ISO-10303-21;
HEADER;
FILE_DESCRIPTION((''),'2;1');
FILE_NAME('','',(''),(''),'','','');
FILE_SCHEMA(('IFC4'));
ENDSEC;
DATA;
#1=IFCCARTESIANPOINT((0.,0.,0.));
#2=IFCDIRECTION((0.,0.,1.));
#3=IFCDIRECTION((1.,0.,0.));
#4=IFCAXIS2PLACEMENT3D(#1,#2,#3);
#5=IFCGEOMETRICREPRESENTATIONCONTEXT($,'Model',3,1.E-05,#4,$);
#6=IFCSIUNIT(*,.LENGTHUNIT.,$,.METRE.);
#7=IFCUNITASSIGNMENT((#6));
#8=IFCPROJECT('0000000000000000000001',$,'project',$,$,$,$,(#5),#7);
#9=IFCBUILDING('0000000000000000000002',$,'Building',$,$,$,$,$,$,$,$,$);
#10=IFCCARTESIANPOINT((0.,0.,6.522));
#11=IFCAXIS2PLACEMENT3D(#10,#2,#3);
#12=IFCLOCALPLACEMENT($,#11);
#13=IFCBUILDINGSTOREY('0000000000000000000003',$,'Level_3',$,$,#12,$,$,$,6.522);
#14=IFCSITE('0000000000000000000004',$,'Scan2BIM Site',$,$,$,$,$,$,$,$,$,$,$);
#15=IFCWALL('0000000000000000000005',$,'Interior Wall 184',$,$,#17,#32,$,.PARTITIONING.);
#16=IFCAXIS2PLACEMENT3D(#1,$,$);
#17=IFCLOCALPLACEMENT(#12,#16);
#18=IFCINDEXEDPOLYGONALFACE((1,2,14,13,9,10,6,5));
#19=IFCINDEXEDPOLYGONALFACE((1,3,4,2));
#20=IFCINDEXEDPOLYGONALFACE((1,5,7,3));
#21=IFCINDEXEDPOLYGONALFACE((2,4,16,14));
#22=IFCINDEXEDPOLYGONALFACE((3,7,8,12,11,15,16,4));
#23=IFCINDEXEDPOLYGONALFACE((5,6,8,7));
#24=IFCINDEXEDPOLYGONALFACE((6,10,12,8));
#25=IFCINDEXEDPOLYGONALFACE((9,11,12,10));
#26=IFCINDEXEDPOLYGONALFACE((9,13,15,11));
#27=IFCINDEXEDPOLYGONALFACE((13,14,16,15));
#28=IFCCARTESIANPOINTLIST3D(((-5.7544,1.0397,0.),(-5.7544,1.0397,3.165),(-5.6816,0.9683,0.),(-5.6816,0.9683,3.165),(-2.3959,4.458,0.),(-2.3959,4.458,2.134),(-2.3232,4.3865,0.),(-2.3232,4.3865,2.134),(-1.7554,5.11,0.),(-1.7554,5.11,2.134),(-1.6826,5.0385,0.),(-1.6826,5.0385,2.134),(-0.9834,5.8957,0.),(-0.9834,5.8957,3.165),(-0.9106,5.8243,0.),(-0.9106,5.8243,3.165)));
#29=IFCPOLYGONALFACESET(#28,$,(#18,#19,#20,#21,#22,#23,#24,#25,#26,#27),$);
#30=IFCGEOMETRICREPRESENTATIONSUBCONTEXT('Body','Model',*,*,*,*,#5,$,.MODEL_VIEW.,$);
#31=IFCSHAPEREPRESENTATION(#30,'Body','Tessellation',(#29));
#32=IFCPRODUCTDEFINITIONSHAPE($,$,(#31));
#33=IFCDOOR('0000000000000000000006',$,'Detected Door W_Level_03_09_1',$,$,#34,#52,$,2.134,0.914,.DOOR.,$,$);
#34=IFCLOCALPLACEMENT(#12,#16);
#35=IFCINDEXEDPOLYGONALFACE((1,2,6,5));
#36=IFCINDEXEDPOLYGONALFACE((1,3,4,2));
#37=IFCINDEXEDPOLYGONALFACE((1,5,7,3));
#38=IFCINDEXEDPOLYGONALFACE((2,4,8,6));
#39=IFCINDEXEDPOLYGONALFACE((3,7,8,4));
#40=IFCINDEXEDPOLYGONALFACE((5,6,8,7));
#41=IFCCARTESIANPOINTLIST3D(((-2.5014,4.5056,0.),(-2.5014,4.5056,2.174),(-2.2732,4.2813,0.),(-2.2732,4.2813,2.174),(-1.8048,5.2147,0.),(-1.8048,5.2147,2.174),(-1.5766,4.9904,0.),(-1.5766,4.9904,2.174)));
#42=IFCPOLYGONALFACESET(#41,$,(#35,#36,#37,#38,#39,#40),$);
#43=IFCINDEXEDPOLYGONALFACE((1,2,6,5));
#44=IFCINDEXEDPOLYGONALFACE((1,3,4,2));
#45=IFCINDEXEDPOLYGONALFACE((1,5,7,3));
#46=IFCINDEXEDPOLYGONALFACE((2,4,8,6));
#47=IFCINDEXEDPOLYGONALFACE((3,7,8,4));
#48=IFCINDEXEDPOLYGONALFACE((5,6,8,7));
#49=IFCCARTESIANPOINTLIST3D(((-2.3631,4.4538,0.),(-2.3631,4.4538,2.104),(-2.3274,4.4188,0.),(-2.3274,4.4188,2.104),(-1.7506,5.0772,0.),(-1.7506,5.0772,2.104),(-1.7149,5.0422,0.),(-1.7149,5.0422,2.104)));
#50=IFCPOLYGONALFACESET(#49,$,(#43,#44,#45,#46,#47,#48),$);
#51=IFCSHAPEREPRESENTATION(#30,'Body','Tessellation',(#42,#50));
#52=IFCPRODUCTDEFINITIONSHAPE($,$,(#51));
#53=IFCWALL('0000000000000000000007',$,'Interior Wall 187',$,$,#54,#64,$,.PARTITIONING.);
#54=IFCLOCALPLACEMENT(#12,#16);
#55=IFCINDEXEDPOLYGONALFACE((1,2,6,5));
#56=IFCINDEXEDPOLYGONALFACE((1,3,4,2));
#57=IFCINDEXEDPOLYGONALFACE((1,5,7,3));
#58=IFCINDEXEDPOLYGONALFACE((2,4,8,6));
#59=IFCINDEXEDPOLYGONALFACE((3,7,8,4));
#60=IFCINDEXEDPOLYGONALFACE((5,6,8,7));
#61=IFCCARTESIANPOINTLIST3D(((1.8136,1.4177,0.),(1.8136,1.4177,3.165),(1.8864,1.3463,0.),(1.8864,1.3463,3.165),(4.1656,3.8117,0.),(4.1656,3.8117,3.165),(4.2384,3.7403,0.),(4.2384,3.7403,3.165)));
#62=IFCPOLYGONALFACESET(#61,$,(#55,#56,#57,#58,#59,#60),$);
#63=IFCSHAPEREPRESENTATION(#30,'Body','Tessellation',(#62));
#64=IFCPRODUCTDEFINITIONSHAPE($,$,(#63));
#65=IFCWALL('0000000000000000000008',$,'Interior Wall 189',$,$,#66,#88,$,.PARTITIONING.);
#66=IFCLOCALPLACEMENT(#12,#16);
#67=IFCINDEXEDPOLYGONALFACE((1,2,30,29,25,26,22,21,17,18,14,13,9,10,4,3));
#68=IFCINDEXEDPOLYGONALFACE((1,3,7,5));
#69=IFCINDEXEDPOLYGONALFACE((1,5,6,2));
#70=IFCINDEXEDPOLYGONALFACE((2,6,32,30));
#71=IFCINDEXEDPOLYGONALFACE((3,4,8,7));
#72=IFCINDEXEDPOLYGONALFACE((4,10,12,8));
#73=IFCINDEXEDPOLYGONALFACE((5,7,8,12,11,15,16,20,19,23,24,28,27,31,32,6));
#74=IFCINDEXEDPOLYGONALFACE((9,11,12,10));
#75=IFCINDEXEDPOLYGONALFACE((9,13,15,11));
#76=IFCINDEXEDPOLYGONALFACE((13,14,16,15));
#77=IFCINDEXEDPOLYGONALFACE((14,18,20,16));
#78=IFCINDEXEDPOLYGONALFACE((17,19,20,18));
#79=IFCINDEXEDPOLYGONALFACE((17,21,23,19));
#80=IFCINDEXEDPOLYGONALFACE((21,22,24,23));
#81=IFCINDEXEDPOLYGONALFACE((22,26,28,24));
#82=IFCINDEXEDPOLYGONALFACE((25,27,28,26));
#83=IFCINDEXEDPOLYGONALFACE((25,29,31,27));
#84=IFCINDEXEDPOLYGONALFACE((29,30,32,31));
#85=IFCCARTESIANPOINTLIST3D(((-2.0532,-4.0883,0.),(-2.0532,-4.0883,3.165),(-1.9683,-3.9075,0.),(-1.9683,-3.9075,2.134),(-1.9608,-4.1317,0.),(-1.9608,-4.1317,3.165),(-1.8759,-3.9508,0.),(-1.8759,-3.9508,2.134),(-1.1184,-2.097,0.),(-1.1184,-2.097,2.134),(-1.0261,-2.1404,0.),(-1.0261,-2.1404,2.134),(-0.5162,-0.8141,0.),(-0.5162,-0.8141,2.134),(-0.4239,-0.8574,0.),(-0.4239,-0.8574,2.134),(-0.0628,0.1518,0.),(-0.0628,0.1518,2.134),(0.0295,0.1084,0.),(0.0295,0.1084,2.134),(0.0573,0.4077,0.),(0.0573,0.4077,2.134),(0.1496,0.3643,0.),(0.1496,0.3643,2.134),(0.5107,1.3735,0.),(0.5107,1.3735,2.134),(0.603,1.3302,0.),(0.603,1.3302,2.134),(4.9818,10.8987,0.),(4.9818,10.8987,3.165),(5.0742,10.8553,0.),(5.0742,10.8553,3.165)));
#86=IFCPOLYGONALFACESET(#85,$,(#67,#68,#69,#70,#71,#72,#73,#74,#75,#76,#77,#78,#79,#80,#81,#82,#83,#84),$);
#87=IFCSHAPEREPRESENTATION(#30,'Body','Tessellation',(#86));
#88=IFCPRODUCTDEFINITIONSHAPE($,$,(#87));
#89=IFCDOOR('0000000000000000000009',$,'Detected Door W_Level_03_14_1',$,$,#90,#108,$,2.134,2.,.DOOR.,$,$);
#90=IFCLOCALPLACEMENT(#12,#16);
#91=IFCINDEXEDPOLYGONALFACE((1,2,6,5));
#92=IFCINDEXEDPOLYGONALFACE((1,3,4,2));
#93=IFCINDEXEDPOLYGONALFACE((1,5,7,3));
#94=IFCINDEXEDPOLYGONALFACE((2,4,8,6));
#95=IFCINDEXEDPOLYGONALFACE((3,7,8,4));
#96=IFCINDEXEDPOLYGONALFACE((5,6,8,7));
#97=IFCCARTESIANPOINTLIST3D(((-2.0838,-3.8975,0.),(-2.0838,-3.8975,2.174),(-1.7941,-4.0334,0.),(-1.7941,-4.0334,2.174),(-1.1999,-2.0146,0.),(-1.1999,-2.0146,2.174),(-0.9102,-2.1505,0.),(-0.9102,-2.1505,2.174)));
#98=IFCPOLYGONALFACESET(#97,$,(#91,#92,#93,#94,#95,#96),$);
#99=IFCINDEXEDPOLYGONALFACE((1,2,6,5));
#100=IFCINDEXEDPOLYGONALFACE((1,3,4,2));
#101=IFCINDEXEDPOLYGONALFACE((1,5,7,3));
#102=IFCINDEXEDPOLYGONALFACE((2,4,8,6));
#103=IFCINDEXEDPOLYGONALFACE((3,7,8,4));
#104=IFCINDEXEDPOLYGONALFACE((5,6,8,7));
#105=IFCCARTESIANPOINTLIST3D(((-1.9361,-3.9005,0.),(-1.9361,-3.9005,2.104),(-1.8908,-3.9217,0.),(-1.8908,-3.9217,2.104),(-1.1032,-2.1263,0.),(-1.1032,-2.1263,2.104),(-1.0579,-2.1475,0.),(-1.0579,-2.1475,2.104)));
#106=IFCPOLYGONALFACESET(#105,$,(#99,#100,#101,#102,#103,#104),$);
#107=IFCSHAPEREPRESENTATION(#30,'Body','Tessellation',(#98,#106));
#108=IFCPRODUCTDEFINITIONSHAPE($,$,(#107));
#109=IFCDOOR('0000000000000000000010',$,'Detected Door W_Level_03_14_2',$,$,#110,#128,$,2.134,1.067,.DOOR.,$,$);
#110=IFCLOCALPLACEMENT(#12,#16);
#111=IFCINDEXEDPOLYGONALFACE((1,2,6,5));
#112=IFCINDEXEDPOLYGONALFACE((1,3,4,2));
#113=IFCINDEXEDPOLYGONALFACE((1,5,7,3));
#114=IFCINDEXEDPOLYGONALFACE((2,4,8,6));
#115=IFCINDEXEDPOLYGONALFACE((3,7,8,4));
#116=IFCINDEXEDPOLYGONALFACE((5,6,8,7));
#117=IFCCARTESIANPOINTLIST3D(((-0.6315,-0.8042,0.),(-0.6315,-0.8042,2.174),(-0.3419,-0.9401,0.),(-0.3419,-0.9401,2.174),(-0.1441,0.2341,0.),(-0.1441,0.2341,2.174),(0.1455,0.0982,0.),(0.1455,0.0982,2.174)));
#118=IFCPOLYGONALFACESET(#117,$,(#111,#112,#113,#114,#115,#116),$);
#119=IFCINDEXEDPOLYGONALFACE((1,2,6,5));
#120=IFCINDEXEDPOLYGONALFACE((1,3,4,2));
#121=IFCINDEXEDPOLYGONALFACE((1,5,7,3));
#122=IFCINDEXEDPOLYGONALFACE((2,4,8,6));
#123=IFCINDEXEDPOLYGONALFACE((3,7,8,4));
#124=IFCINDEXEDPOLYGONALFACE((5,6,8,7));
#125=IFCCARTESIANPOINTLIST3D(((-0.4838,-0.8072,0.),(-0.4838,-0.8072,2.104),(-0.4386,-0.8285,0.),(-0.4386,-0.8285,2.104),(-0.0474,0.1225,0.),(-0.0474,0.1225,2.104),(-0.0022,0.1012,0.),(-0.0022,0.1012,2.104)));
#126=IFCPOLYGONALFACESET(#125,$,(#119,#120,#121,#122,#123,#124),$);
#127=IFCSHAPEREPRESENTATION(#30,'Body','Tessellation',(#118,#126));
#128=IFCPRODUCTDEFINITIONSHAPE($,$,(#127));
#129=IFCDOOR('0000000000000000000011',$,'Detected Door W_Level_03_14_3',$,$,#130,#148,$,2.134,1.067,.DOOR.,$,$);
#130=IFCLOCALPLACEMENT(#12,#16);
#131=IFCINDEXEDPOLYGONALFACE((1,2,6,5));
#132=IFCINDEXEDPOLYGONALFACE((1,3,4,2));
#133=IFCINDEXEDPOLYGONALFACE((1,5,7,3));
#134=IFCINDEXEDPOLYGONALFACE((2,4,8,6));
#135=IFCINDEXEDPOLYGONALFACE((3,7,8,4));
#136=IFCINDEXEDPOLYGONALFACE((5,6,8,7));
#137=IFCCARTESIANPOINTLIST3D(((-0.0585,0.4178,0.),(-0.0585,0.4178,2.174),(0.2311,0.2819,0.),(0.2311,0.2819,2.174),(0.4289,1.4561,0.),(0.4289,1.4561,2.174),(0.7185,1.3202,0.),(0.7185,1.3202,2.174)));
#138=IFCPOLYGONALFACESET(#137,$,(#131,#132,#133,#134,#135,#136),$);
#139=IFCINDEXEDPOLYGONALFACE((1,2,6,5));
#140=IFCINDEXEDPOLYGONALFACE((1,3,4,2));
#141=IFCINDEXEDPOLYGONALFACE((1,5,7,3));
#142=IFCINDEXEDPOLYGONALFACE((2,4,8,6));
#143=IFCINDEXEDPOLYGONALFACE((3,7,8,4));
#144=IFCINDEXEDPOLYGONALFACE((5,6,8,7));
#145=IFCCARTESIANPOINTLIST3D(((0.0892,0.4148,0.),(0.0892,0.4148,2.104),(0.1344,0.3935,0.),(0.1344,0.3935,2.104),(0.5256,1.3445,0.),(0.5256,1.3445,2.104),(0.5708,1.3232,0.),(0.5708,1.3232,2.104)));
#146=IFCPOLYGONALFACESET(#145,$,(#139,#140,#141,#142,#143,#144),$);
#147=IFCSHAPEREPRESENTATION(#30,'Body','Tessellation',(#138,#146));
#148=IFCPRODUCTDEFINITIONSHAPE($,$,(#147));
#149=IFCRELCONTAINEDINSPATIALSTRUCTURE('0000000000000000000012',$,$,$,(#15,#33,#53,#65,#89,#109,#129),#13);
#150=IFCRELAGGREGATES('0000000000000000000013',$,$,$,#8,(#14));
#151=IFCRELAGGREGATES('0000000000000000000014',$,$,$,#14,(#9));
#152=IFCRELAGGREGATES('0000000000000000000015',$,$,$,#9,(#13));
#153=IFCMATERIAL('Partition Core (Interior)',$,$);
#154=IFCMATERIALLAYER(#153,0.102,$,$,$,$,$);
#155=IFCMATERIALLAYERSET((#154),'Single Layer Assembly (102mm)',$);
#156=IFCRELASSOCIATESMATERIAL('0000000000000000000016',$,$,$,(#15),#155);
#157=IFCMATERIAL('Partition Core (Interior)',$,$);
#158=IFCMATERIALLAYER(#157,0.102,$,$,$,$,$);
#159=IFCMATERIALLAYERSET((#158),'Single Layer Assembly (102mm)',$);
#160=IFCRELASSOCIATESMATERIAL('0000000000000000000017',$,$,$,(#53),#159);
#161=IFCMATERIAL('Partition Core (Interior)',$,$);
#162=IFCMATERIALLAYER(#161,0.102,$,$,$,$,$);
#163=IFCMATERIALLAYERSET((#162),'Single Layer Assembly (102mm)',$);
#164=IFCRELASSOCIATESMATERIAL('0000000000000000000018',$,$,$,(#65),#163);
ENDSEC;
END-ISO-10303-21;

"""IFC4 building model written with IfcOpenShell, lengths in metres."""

from ifc_helpers import new_model, si_unit, frame, origin, origin_with_axes, place, context, subcontext, project, spatial, rectangle, extrude, material, layer, layer_set, element, fill, save


model = new_model("IFC4")

# Units and contexts
model_context = context("Model", 3, precision=1e-05, world=origin_with_axes())
body_context = subcontext(model_context, "Body", "Model", "MODEL_VIEW")
ifc_project = project(units=[si_unit("LENGTHUNIT", "METRE")], contexts=[model_context])

# Site, building, storey
site = spatial("IfcSite", under=ifc_project, Name="Scan2BIM Site")
building = spatial("IfcBuilding", under=site, Name="Building")
storey_placement = place(None, frame((0.0, 0.0, 6.522), z_axis=(0.0, 0.0, 1.0), x_axis=(1.0, 0.0, 0.0)))
storey = spatial("IfcBuildingStorey", under=building, at=storey_placement, Name="Level_3", Elevation=6.522)

# Wall, opening, door
ifc_material_1 = material(Name="Partition Core (Interior)")
ifc_layer_1 = layer(ifc_material_1, 0.102)
ifc_layer_set_1 = layer_set([ifc_layer_1], Name="Single Layer Assembly (102mm)")
wall_1_placement = place(storey_placement, frame((-3.3325, 3.432, 0.0), z_axis=(0.0, 0.0, 1.0), x_axis=(0.700836, 0.713322, 0.0)))
wall_1 = element("IfcWall", 1, at=wall_1_placement, inside=storey, material=ifc_layer_set_1, Name="Interior Wall 184", PredefinedType="PARTITIONING", context=body_context, shape_type="SweptSolid", body=[
    extrude(rectangle(XDim=6.8076, YDim=0.102), origin(), (0.0, 0.0, 1.0), 3.165),
])
opening_1_placement = place(None, frame((-2.039, 4.748, 6.522), z_axis=(0.0, 0.0, 1.0), x_axis=(0.700836, 0.713322, 0.0)))
opening_1 = element("IfcOpeningElement", 2, at=opening_1_placement, cuts=wall_1, PredefinedType="OPENING", context=body_context, shape_type="SweptSolid", body=[
    extrude(rectangle(XDim=0.914, YDim=0.202), origin(), (0.0, 0.0, 1.0), 2.134),
])
door_1_placement = place(opening_1_placement, frame((0.0, 0.0, 0.0), z_axis=(0.0, 0.0, 1.0), x_axis=(1.0, 0.0, 0.0)))
door_1 = element("IfcDoor", 3, at=door_1_placement, inside=storey, Name="Detected Door W_Level_03_09_1", OverallHeight=2.134, OverallWidth=0.914, PredefinedType="DOOR", context=body_context, shape_type="SweptSolid", body=[
    extrude(rectangle(XDim=0.994, YDim=0.32), origin(), (0.0, 0.0, 1.0), 2.174),
    extrude(rectangle(XDim=0.874, YDim=0.05), origin(), (0.0, 0.0, 1.0), 2.104),
])
fill(opening_1, door_1)

# Wall
ifc_material_2 = material(Name="Partition Core (Interior)")
ifc_layer_2 = layer(ifc_material_2, 0.102)
ifc_layer_set_2 = layer_set([ifc_layer_2], Name="Single Layer Assembly (102mm)")
wall_2_placement = place(storey_placement, frame((3.026, 2.579, 0.0), z_axis=(0.0, 0.0, 1.0), x_axis=(0.700822, 0.713336, 0.0)))
element("IfcWall", 4, at=wall_2_placement, inside=storey, material=ifc_layer_set_2, Name="Interior Wall 187", PredefinedType="PARTITIONING", context=body_context, shape_type="SweptSolid", body=[
    extrude(rectangle(XDim=3.3561, YDim=0.102), origin(), (0.0, 0.0, 1.0), 3.165),
])

# Wall, openings, doors
ifc_material_3 = material(Name="Partition Core (Interior)")
ifc_layer_3 = layer(ifc_material_3, 0.102)
ifc_layer_set_3 = layer_set([ifc_layer_3], Name="Single Layer Assembly (102mm)")
wall_3_placement = place(storey_placement, frame((1.5105, 3.3835, 0.0), z_axis=(0.0, 0.0, 1.0), x_axis=(0.424921, 0.90523, 0.0)))
wall_3 = element("IfcWall", 5, at=wall_3_placement, inside=storey, material=ifc_layer_set_3, Name="Interior Wall 189", PredefinedType="PARTITIONING", context=body_context, shape_type="SweptSolid", body=[
    extrude(rectangle(XDim=16.556, YDim=0.102), origin(), (0.0, 0.0, 1.0), 3.165),
])
opening_2_placement = place(None, frame((-1.497, -3.024, 6.522), z_axis=(0.0, 0.0, 1.0), x_axis=(0.424921, 0.90523, 0.0)))
opening_2 = element("IfcOpeningElement", 6, at=opening_2_placement, cuts=wall_3, PredefinedType="OPENING", context=body_context, shape_type="SweptSolid", body=[
    extrude(rectangle(XDim=2.0, YDim=0.202), origin(), (0.0, 0.0, 1.0), 2.134),
])
opening_3_placement = place(None, frame((-0.243, -0.353, 6.522), z_axis=(0.0, 0.0, 1.0), x_axis=(0.424921, 0.90523, 0.0)))
opening_3 = element("IfcOpeningElement", 7, at=opening_3_placement, cuts=wall_3, PredefinedType="OPENING", context=body_context, shape_type="SweptSolid", body=[
    extrude(rectangle(XDim=1.067, YDim=0.202), origin(), (0.0, 0.0, 1.0), 2.134),
])
opening_4_placement = place(None, frame((0.33, 0.869, 6.522), z_axis=(0.0, 0.0, 1.0), x_axis=(0.424921, 0.90523, 0.0)))
opening_4 = element("IfcOpeningElement", 8, at=opening_4_placement, cuts=wall_3, PredefinedType="OPENING", context=body_context, shape_type="SweptSolid", body=[
    extrude(rectangle(XDim=1.067, YDim=0.202), origin(), (0.0, 0.0, 1.0), 2.134),
])
door_2_placement = place(opening_2_placement, frame((0.0, 0.0, 0.0), z_axis=(0.0, 0.0, 1.0), x_axis=(1.0, 0.0, 0.0)))
door_2 = element("IfcDoor", 9, at=door_2_placement, inside=storey, Name="Detected Door W_Level_03_14_1", OverallHeight=2.134, OverallWidth=2.0, PredefinedType="DOOR", context=body_context, shape_type="SweptSolid", body=[
    extrude(rectangle(XDim=2.08, YDim=0.32), origin(), (0.0, 0.0, 1.0), 2.174),
    extrude(rectangle(XDim=1.96, YDim=0.05), origin(), (0.0, 0.0, 1.0), 2.104),
])
fill(opening_2, door_2)
door_3_placement = place(opening_3_placement, frame((0.0, 0.0, 0.0), z_axis=(0.0, 0.0, 1.0), x_axis=(1.0, 0.0, 0.0)))
door_3 = element("IfcDoor", 10, at=door_3_placement, inside=storey, Name="Detected Door W_Level_03_14_2", OverallHeight=2.134, OverallWidth=1.067, PredefinedType="DOOR", context=body_context, shape_type="SweptSolid", body=[
    extrude(rectangle(XDim=1.147, YDim=0.32), origin(), (0.0, 0.0, 1.0), 2.174),
    extrude(rectangle(XDim=1.027, YDim=0.05), origin(), (0.0, 0.0, 1.0), 2.104),
])
fill(opening_3, door_3)
door_4_placement = place(opening_4_placement, frame((0.0, 0.0, 0.0), z_axis=(0.0, 0.0, 1.0), x_axis=(1.0, 0.0, 0.0)))
door_4 = element("IfcDoor", 11, at=door_4_placement, inside=storey, Name="Detected Door W_Level_03_14_3", OverallHeight=2.134, OverallWidth=1.067, PredefinedType="DOOR", context=body_context, shape_type="SweptSolid", body=[
    extrude(rectangle(XDim=1.147, YDim=0.32), origin(), (0.0, 0.0, 1.0), 2.174),
    extrude(rectangle(XDim=1.027, YDim=0.05), origin(), (0.0, 0.0, 1.0), 2.104),
])
fill(opening_4, door_4)

save(model, "model.ifc")
